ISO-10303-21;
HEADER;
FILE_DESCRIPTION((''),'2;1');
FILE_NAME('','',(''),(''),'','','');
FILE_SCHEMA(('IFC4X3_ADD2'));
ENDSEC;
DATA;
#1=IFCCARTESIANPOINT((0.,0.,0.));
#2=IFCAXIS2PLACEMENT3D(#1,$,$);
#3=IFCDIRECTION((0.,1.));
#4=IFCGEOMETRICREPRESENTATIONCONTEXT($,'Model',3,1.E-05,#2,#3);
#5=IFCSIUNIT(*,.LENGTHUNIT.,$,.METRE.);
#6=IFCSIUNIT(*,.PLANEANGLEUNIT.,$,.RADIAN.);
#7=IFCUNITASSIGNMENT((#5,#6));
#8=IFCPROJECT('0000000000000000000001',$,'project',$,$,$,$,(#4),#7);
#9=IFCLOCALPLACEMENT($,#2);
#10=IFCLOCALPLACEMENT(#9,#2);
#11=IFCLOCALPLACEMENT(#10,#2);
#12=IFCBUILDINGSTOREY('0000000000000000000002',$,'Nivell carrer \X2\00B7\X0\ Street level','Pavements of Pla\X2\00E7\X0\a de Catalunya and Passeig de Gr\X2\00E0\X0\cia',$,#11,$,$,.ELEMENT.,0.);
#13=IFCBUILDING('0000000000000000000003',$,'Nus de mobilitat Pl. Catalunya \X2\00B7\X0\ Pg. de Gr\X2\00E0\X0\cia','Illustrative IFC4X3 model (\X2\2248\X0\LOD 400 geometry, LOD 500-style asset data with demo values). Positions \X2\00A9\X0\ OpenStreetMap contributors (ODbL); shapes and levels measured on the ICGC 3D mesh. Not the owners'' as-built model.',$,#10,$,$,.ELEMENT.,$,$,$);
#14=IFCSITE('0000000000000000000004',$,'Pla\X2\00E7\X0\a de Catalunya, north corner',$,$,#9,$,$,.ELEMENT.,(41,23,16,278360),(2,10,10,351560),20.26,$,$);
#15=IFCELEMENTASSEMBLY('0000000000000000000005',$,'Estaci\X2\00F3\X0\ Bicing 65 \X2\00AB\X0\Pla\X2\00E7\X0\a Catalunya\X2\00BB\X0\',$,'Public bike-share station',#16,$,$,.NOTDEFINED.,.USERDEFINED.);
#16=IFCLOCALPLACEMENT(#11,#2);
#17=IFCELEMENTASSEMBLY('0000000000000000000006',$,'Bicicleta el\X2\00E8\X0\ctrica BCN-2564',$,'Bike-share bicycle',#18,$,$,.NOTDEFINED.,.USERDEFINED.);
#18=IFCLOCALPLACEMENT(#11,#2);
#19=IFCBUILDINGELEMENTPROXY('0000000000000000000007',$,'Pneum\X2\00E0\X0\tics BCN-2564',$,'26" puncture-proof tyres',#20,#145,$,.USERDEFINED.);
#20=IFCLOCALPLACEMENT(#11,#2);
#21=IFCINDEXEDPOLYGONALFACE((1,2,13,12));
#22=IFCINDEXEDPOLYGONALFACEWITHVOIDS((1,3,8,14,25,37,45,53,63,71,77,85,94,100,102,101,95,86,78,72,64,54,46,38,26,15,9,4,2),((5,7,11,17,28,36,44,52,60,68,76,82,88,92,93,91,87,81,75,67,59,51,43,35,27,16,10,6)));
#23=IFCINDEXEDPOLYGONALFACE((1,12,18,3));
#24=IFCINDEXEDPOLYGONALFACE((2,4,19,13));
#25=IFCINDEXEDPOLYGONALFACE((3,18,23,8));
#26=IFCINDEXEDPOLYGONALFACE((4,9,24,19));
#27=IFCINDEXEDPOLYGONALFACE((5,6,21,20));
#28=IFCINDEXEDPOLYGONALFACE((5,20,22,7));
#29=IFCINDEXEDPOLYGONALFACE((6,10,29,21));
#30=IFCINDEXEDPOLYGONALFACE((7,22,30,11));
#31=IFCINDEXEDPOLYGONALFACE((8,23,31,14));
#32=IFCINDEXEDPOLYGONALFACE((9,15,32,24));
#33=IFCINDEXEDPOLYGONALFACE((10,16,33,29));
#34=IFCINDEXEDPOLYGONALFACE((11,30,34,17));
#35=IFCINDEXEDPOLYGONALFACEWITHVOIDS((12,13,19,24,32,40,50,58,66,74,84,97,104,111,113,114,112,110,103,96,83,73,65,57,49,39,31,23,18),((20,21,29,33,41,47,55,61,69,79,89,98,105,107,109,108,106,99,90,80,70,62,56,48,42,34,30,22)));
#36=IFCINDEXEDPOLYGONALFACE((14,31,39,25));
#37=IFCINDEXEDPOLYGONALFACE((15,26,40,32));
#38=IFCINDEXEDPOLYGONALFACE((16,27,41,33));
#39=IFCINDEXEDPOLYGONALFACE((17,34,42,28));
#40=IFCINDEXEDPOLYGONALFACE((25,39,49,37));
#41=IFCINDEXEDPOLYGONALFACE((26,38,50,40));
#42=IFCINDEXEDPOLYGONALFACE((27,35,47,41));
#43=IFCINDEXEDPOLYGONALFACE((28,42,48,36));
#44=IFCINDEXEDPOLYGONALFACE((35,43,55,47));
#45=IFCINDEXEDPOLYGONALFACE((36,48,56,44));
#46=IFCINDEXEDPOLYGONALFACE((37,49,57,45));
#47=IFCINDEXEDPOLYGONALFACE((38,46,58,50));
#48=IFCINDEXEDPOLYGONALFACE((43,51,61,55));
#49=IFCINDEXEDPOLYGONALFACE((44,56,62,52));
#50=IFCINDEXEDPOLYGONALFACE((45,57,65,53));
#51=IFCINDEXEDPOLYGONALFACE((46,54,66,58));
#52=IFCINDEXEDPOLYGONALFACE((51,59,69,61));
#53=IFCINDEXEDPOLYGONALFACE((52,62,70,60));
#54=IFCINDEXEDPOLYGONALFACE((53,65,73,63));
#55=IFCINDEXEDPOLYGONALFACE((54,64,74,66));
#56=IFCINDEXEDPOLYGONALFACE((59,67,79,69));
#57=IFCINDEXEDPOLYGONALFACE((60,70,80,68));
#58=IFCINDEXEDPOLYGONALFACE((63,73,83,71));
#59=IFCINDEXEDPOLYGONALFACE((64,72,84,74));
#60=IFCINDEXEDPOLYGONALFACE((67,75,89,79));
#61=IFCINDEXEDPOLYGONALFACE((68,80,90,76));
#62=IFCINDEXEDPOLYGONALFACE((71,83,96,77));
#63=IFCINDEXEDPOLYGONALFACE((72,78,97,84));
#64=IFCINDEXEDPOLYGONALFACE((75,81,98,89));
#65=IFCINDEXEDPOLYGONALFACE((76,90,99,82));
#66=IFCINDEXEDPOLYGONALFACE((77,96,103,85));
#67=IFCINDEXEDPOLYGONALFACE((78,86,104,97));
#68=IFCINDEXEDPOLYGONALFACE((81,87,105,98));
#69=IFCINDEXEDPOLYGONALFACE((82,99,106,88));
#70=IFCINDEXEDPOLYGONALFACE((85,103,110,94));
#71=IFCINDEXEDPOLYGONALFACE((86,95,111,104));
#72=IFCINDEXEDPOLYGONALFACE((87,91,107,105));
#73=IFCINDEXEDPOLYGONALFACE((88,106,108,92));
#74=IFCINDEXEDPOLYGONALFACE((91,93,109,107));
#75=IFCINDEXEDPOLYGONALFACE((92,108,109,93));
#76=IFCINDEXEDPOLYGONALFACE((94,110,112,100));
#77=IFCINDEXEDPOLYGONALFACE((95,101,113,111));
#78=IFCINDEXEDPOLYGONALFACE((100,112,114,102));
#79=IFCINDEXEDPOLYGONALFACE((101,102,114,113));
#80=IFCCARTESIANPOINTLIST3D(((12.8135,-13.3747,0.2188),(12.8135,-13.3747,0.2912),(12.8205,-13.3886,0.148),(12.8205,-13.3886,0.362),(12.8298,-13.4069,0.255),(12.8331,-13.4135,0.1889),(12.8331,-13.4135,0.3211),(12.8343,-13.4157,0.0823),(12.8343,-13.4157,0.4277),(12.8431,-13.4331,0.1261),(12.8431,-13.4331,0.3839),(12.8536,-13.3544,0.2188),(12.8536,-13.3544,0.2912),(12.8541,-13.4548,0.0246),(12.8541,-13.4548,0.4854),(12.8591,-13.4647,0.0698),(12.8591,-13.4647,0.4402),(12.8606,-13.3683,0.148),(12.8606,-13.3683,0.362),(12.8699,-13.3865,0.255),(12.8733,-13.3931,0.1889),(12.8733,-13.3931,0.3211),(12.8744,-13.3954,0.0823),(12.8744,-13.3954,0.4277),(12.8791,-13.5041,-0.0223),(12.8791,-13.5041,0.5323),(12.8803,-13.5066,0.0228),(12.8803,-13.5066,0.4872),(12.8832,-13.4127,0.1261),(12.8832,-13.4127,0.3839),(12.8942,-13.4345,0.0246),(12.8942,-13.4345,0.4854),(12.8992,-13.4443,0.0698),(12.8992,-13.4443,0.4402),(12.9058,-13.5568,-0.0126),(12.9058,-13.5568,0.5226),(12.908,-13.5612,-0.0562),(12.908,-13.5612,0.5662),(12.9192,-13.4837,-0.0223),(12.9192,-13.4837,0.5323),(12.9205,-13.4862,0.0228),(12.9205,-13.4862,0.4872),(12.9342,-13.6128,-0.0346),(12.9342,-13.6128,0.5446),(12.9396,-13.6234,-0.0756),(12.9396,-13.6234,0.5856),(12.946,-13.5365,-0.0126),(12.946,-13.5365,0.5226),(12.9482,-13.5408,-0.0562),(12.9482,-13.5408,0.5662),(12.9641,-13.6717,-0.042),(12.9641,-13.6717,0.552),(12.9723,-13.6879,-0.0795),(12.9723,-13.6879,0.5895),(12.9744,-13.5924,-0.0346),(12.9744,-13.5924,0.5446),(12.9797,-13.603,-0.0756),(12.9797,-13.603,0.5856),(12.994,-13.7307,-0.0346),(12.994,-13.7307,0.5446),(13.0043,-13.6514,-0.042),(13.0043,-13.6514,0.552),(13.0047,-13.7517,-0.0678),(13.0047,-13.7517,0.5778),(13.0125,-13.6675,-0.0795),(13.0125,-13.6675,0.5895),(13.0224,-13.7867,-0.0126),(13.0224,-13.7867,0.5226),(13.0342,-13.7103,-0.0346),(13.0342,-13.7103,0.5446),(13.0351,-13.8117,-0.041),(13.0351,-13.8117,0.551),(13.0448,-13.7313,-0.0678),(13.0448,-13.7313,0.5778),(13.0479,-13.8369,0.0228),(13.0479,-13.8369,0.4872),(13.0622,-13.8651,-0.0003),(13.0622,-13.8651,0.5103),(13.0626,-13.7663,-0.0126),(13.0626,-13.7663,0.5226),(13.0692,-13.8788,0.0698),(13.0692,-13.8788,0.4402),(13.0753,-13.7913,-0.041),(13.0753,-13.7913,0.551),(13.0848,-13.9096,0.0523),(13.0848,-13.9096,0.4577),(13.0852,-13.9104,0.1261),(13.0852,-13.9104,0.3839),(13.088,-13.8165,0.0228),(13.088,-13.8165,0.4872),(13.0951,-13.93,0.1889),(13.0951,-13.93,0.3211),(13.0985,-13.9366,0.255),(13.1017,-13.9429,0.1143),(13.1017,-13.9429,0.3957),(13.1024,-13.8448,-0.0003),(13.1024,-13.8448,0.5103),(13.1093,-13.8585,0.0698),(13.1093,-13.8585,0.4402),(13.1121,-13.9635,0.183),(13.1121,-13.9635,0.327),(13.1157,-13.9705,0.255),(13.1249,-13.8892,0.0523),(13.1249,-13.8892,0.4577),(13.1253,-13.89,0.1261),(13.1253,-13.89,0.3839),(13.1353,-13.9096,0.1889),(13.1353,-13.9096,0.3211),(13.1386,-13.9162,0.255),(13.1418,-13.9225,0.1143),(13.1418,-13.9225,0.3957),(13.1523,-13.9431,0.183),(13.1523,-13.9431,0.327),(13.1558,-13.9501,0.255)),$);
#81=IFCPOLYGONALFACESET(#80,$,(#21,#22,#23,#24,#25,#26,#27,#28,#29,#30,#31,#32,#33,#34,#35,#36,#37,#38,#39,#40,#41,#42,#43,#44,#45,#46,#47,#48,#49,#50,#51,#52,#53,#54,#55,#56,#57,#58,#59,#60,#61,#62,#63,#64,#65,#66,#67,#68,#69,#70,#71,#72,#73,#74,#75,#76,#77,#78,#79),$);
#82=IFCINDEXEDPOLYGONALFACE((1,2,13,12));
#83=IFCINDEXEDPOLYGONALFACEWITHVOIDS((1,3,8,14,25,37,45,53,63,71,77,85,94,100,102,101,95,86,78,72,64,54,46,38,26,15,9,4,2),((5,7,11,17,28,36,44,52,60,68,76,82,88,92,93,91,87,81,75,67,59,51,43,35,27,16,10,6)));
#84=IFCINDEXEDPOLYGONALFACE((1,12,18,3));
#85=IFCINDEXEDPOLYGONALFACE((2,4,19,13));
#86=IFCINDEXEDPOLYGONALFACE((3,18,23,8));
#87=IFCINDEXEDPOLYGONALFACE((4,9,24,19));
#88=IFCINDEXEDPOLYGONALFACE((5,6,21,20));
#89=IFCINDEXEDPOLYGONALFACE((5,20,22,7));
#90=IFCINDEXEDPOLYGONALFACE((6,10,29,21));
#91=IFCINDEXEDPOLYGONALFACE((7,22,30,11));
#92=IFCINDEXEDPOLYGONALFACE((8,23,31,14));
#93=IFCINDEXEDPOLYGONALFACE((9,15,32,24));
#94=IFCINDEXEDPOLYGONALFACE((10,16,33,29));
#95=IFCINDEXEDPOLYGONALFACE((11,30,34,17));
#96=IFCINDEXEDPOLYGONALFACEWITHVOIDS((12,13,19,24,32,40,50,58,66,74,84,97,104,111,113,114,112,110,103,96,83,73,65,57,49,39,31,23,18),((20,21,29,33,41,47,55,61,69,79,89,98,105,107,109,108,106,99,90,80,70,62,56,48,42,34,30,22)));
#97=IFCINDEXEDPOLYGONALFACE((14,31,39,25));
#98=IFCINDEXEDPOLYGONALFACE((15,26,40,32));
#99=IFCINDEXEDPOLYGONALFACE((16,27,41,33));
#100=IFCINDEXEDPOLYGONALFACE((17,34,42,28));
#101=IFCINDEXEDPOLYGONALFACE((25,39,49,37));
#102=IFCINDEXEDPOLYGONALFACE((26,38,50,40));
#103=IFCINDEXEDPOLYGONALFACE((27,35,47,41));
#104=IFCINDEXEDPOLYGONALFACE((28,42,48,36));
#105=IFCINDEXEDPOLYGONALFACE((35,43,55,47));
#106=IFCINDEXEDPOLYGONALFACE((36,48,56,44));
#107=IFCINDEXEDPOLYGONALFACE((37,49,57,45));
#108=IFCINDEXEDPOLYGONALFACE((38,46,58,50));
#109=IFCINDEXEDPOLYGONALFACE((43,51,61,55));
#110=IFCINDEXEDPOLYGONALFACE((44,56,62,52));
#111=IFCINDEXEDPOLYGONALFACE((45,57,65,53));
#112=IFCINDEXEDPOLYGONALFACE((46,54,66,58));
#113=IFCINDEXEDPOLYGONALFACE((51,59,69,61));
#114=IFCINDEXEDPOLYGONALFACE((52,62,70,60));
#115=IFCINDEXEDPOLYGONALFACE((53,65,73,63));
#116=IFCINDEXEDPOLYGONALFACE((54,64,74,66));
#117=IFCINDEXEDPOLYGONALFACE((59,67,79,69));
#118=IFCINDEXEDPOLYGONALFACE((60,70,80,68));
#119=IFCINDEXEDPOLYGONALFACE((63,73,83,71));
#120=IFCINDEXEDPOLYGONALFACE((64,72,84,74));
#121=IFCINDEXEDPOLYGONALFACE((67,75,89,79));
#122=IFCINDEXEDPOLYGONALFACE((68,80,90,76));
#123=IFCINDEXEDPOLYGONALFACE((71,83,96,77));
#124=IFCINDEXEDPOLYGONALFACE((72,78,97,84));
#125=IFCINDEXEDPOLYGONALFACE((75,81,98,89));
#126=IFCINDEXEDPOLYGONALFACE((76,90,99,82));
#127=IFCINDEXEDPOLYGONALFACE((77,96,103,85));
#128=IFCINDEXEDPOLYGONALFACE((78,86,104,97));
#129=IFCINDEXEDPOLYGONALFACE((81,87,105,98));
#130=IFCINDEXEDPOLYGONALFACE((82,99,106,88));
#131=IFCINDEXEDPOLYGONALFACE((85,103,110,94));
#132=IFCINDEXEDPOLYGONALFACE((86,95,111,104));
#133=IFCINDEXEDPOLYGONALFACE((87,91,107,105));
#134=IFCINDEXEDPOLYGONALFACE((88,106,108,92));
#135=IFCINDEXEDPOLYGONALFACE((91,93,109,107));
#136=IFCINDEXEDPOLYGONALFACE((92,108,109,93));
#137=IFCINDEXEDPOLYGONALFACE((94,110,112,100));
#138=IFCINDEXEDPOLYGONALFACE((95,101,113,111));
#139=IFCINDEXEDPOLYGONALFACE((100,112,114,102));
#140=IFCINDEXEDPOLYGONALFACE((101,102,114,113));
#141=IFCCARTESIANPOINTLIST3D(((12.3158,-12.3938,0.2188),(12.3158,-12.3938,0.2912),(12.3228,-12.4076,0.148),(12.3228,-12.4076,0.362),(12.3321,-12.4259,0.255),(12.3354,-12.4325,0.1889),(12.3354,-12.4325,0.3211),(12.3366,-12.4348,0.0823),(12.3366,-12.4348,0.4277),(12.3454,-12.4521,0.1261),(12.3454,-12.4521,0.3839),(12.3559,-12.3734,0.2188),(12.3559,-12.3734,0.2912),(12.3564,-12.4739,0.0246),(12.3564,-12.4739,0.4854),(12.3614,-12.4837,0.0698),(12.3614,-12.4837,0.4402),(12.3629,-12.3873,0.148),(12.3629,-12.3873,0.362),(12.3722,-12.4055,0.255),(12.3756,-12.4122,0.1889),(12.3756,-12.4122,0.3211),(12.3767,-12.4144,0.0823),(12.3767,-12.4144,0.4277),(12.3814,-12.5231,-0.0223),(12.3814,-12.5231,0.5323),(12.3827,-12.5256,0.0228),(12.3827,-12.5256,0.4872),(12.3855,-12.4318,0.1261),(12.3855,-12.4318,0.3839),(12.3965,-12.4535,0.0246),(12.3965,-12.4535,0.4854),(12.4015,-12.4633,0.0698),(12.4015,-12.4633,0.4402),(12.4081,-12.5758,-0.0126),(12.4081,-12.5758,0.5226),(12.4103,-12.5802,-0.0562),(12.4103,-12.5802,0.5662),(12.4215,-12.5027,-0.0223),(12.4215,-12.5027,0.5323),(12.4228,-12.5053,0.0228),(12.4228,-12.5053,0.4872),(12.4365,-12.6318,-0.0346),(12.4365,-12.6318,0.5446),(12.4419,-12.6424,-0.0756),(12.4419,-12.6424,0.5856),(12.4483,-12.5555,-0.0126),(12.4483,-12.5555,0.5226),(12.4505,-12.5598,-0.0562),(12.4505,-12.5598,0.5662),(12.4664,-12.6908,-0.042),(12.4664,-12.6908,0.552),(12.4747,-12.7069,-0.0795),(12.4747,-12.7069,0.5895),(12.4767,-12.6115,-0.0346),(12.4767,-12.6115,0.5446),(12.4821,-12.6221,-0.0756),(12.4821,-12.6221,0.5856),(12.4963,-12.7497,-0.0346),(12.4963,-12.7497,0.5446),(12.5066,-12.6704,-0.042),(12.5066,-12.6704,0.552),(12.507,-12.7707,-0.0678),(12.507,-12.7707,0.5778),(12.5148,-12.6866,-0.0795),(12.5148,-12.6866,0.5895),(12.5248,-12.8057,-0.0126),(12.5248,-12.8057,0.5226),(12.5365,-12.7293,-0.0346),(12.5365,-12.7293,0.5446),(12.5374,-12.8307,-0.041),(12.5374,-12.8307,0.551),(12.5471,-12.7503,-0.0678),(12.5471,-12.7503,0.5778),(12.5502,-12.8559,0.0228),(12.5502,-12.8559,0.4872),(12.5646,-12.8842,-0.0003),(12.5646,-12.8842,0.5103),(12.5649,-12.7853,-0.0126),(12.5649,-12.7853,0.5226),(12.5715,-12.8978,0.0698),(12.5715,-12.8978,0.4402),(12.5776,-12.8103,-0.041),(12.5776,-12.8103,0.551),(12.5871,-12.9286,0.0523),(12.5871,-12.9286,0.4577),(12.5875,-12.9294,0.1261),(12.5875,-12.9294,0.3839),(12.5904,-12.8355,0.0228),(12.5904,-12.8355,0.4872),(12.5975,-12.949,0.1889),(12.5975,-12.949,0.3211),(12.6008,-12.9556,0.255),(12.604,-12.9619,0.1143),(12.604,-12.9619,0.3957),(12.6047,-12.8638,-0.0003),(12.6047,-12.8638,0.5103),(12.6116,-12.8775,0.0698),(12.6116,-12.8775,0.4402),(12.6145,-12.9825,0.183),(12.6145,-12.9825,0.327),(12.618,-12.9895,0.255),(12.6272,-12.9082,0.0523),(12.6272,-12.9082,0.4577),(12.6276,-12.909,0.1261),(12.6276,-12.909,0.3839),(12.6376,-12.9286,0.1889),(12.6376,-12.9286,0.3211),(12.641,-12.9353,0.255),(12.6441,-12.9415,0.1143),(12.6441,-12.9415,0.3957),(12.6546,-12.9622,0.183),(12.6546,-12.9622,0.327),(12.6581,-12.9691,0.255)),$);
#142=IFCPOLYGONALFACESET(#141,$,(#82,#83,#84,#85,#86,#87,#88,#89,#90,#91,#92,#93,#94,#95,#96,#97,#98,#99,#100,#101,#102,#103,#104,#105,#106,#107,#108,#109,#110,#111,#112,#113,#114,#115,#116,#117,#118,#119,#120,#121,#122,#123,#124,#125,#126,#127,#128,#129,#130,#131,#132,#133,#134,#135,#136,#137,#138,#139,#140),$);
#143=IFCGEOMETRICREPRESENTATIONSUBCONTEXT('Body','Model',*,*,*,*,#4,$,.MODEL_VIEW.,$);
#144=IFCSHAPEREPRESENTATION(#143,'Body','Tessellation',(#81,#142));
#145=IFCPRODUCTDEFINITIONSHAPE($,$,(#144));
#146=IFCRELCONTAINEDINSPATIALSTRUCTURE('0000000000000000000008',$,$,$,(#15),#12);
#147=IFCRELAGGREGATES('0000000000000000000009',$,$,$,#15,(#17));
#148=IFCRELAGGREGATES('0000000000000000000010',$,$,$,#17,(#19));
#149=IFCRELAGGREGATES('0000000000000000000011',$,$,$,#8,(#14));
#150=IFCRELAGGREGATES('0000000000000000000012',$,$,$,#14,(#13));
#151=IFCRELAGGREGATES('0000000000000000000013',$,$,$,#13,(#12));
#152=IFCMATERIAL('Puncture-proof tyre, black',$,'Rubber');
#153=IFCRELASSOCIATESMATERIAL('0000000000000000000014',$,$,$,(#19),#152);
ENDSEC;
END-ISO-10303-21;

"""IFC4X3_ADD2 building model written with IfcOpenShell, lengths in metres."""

from ifc_helpers import new_model, si_unit, direction, frame, origin, origin_2d_with_axis, place, context, subcontext, project, spatial, hollow_circle, extrude, material, element, aggregate, save


model = new_model("IFC4X3_ADD2")

# Units and contexts
model_context = context("Model", 3, precision=1e-05, world=origin(), true_north=direction((0.0, 1.0)))
body_context = subcontext(model_context, "Body", "Model", "MODEL_VIEW")
ifc_project = project(units=[si_unit("LENGTHUNIT", "METRE"), si_unit("PLANEANGLEUNIT", "RADIAN")], contexts=[model_context])

# Site, building, storey
site_placement = place(None, origin())
site = spatial("IfcSite", under=ifc_project, at=site_placement, Name="Plaça de Catalunya, north corner", CompositionType="ELEMENT", RefLatitude=(41, 23, 16, 278360), RefLongitude=(2, 10, 10, 351560), RefElevation=20.26)
building_placement = place(site_placement, origin())
building = spatial("IfcBuilding", under=site, at=building_placement, Name="Nus de mobilitat Pl. Catalunya · Pg. de Gràcia", Description="Illustrative IFC4X3 model (≈LOD 400 geometry, LOD 500-style asset data with demo values). Positions © OpenStreetMap contributors (ODbL); shapes and levels measured on the ICGC 3D mesh. Not the owners' as-built model.", CompositionType="ELEMENT")
storey_placement = place(building_placement, origin())
storey = spatial("IfcBuildingStorey", under=building, at=storey_placement, Name="Nivell carrer · Street level", Description="Pavements of Plaça de Catalunya and Passeig de Gràcia", CompositionType="ELEMENT", Elevation=0.0)

# Element assemblies
assembly_1_placement = place(building_placement, origin())
assembly_1 = element("IfcElementAssembly", 1, at=assembly_1_placement, inside=storey, Name="Estació Bicing 65 «Plaça Catalunya»", ObjectType="Public bike-share station", AssemblyPlace="NOTDEFINED", PredefinedType="USERDEFINED")
assembly_2_placement = place(building_placement, origin())
assembly_2 = element("IfcElementAssembly", 2, at=assembly_2_placement, Name="Bicicleta elèctrica BCN-2564", ObjectType="Bike-share bicycle", AssemblyPlace="NOTDEFINED", PredefinedType="USERDEFINED")
aggregate(assembly_1, [assembly_2])

# Building element proxy
ifc_material_1 = material(Name="Puncture-proof tyre, black", Category="Rubber")
proxy_1_placement = place(building_placement, origin())
proxy_1 = element("IfcBuildingElementProxy", 3, at=proxy_1_placement, material=ifc_material_1, Name="Pneumàtics BCN-2564", ObjectType="26\" puncture-proof tyres", PredefinedType="USERDEFINED", context=body_context, shape_type="SweptSolid", body=[
    extrude(hollow_circle(Radius=0.335, WallThickness=0.038, at=origin_2d_with_axis()), frame((12.9641, -13.6717, 0.255), z_axis=(0.891798, 0.452435, 0.0), x_axis=(0.452435, -0.891798, 0.0)), (0.0, 0.0, 1.0), 0.045),
    extrude(hollow_circle(Radius=0.335, WallThickness=0.038, at=origin_2d_with_axis()), frame((12.4664, -12.6908, 0.255), z_axis=(0.891798, 0.452435, 0.0), x_axis=(0.452435, -0.891798, 0.0)), (0.0, 0.0, 1.0), 0.045),
])
aggregate(assembly_2, [proxy_1])

save(model, "model.ifc")
